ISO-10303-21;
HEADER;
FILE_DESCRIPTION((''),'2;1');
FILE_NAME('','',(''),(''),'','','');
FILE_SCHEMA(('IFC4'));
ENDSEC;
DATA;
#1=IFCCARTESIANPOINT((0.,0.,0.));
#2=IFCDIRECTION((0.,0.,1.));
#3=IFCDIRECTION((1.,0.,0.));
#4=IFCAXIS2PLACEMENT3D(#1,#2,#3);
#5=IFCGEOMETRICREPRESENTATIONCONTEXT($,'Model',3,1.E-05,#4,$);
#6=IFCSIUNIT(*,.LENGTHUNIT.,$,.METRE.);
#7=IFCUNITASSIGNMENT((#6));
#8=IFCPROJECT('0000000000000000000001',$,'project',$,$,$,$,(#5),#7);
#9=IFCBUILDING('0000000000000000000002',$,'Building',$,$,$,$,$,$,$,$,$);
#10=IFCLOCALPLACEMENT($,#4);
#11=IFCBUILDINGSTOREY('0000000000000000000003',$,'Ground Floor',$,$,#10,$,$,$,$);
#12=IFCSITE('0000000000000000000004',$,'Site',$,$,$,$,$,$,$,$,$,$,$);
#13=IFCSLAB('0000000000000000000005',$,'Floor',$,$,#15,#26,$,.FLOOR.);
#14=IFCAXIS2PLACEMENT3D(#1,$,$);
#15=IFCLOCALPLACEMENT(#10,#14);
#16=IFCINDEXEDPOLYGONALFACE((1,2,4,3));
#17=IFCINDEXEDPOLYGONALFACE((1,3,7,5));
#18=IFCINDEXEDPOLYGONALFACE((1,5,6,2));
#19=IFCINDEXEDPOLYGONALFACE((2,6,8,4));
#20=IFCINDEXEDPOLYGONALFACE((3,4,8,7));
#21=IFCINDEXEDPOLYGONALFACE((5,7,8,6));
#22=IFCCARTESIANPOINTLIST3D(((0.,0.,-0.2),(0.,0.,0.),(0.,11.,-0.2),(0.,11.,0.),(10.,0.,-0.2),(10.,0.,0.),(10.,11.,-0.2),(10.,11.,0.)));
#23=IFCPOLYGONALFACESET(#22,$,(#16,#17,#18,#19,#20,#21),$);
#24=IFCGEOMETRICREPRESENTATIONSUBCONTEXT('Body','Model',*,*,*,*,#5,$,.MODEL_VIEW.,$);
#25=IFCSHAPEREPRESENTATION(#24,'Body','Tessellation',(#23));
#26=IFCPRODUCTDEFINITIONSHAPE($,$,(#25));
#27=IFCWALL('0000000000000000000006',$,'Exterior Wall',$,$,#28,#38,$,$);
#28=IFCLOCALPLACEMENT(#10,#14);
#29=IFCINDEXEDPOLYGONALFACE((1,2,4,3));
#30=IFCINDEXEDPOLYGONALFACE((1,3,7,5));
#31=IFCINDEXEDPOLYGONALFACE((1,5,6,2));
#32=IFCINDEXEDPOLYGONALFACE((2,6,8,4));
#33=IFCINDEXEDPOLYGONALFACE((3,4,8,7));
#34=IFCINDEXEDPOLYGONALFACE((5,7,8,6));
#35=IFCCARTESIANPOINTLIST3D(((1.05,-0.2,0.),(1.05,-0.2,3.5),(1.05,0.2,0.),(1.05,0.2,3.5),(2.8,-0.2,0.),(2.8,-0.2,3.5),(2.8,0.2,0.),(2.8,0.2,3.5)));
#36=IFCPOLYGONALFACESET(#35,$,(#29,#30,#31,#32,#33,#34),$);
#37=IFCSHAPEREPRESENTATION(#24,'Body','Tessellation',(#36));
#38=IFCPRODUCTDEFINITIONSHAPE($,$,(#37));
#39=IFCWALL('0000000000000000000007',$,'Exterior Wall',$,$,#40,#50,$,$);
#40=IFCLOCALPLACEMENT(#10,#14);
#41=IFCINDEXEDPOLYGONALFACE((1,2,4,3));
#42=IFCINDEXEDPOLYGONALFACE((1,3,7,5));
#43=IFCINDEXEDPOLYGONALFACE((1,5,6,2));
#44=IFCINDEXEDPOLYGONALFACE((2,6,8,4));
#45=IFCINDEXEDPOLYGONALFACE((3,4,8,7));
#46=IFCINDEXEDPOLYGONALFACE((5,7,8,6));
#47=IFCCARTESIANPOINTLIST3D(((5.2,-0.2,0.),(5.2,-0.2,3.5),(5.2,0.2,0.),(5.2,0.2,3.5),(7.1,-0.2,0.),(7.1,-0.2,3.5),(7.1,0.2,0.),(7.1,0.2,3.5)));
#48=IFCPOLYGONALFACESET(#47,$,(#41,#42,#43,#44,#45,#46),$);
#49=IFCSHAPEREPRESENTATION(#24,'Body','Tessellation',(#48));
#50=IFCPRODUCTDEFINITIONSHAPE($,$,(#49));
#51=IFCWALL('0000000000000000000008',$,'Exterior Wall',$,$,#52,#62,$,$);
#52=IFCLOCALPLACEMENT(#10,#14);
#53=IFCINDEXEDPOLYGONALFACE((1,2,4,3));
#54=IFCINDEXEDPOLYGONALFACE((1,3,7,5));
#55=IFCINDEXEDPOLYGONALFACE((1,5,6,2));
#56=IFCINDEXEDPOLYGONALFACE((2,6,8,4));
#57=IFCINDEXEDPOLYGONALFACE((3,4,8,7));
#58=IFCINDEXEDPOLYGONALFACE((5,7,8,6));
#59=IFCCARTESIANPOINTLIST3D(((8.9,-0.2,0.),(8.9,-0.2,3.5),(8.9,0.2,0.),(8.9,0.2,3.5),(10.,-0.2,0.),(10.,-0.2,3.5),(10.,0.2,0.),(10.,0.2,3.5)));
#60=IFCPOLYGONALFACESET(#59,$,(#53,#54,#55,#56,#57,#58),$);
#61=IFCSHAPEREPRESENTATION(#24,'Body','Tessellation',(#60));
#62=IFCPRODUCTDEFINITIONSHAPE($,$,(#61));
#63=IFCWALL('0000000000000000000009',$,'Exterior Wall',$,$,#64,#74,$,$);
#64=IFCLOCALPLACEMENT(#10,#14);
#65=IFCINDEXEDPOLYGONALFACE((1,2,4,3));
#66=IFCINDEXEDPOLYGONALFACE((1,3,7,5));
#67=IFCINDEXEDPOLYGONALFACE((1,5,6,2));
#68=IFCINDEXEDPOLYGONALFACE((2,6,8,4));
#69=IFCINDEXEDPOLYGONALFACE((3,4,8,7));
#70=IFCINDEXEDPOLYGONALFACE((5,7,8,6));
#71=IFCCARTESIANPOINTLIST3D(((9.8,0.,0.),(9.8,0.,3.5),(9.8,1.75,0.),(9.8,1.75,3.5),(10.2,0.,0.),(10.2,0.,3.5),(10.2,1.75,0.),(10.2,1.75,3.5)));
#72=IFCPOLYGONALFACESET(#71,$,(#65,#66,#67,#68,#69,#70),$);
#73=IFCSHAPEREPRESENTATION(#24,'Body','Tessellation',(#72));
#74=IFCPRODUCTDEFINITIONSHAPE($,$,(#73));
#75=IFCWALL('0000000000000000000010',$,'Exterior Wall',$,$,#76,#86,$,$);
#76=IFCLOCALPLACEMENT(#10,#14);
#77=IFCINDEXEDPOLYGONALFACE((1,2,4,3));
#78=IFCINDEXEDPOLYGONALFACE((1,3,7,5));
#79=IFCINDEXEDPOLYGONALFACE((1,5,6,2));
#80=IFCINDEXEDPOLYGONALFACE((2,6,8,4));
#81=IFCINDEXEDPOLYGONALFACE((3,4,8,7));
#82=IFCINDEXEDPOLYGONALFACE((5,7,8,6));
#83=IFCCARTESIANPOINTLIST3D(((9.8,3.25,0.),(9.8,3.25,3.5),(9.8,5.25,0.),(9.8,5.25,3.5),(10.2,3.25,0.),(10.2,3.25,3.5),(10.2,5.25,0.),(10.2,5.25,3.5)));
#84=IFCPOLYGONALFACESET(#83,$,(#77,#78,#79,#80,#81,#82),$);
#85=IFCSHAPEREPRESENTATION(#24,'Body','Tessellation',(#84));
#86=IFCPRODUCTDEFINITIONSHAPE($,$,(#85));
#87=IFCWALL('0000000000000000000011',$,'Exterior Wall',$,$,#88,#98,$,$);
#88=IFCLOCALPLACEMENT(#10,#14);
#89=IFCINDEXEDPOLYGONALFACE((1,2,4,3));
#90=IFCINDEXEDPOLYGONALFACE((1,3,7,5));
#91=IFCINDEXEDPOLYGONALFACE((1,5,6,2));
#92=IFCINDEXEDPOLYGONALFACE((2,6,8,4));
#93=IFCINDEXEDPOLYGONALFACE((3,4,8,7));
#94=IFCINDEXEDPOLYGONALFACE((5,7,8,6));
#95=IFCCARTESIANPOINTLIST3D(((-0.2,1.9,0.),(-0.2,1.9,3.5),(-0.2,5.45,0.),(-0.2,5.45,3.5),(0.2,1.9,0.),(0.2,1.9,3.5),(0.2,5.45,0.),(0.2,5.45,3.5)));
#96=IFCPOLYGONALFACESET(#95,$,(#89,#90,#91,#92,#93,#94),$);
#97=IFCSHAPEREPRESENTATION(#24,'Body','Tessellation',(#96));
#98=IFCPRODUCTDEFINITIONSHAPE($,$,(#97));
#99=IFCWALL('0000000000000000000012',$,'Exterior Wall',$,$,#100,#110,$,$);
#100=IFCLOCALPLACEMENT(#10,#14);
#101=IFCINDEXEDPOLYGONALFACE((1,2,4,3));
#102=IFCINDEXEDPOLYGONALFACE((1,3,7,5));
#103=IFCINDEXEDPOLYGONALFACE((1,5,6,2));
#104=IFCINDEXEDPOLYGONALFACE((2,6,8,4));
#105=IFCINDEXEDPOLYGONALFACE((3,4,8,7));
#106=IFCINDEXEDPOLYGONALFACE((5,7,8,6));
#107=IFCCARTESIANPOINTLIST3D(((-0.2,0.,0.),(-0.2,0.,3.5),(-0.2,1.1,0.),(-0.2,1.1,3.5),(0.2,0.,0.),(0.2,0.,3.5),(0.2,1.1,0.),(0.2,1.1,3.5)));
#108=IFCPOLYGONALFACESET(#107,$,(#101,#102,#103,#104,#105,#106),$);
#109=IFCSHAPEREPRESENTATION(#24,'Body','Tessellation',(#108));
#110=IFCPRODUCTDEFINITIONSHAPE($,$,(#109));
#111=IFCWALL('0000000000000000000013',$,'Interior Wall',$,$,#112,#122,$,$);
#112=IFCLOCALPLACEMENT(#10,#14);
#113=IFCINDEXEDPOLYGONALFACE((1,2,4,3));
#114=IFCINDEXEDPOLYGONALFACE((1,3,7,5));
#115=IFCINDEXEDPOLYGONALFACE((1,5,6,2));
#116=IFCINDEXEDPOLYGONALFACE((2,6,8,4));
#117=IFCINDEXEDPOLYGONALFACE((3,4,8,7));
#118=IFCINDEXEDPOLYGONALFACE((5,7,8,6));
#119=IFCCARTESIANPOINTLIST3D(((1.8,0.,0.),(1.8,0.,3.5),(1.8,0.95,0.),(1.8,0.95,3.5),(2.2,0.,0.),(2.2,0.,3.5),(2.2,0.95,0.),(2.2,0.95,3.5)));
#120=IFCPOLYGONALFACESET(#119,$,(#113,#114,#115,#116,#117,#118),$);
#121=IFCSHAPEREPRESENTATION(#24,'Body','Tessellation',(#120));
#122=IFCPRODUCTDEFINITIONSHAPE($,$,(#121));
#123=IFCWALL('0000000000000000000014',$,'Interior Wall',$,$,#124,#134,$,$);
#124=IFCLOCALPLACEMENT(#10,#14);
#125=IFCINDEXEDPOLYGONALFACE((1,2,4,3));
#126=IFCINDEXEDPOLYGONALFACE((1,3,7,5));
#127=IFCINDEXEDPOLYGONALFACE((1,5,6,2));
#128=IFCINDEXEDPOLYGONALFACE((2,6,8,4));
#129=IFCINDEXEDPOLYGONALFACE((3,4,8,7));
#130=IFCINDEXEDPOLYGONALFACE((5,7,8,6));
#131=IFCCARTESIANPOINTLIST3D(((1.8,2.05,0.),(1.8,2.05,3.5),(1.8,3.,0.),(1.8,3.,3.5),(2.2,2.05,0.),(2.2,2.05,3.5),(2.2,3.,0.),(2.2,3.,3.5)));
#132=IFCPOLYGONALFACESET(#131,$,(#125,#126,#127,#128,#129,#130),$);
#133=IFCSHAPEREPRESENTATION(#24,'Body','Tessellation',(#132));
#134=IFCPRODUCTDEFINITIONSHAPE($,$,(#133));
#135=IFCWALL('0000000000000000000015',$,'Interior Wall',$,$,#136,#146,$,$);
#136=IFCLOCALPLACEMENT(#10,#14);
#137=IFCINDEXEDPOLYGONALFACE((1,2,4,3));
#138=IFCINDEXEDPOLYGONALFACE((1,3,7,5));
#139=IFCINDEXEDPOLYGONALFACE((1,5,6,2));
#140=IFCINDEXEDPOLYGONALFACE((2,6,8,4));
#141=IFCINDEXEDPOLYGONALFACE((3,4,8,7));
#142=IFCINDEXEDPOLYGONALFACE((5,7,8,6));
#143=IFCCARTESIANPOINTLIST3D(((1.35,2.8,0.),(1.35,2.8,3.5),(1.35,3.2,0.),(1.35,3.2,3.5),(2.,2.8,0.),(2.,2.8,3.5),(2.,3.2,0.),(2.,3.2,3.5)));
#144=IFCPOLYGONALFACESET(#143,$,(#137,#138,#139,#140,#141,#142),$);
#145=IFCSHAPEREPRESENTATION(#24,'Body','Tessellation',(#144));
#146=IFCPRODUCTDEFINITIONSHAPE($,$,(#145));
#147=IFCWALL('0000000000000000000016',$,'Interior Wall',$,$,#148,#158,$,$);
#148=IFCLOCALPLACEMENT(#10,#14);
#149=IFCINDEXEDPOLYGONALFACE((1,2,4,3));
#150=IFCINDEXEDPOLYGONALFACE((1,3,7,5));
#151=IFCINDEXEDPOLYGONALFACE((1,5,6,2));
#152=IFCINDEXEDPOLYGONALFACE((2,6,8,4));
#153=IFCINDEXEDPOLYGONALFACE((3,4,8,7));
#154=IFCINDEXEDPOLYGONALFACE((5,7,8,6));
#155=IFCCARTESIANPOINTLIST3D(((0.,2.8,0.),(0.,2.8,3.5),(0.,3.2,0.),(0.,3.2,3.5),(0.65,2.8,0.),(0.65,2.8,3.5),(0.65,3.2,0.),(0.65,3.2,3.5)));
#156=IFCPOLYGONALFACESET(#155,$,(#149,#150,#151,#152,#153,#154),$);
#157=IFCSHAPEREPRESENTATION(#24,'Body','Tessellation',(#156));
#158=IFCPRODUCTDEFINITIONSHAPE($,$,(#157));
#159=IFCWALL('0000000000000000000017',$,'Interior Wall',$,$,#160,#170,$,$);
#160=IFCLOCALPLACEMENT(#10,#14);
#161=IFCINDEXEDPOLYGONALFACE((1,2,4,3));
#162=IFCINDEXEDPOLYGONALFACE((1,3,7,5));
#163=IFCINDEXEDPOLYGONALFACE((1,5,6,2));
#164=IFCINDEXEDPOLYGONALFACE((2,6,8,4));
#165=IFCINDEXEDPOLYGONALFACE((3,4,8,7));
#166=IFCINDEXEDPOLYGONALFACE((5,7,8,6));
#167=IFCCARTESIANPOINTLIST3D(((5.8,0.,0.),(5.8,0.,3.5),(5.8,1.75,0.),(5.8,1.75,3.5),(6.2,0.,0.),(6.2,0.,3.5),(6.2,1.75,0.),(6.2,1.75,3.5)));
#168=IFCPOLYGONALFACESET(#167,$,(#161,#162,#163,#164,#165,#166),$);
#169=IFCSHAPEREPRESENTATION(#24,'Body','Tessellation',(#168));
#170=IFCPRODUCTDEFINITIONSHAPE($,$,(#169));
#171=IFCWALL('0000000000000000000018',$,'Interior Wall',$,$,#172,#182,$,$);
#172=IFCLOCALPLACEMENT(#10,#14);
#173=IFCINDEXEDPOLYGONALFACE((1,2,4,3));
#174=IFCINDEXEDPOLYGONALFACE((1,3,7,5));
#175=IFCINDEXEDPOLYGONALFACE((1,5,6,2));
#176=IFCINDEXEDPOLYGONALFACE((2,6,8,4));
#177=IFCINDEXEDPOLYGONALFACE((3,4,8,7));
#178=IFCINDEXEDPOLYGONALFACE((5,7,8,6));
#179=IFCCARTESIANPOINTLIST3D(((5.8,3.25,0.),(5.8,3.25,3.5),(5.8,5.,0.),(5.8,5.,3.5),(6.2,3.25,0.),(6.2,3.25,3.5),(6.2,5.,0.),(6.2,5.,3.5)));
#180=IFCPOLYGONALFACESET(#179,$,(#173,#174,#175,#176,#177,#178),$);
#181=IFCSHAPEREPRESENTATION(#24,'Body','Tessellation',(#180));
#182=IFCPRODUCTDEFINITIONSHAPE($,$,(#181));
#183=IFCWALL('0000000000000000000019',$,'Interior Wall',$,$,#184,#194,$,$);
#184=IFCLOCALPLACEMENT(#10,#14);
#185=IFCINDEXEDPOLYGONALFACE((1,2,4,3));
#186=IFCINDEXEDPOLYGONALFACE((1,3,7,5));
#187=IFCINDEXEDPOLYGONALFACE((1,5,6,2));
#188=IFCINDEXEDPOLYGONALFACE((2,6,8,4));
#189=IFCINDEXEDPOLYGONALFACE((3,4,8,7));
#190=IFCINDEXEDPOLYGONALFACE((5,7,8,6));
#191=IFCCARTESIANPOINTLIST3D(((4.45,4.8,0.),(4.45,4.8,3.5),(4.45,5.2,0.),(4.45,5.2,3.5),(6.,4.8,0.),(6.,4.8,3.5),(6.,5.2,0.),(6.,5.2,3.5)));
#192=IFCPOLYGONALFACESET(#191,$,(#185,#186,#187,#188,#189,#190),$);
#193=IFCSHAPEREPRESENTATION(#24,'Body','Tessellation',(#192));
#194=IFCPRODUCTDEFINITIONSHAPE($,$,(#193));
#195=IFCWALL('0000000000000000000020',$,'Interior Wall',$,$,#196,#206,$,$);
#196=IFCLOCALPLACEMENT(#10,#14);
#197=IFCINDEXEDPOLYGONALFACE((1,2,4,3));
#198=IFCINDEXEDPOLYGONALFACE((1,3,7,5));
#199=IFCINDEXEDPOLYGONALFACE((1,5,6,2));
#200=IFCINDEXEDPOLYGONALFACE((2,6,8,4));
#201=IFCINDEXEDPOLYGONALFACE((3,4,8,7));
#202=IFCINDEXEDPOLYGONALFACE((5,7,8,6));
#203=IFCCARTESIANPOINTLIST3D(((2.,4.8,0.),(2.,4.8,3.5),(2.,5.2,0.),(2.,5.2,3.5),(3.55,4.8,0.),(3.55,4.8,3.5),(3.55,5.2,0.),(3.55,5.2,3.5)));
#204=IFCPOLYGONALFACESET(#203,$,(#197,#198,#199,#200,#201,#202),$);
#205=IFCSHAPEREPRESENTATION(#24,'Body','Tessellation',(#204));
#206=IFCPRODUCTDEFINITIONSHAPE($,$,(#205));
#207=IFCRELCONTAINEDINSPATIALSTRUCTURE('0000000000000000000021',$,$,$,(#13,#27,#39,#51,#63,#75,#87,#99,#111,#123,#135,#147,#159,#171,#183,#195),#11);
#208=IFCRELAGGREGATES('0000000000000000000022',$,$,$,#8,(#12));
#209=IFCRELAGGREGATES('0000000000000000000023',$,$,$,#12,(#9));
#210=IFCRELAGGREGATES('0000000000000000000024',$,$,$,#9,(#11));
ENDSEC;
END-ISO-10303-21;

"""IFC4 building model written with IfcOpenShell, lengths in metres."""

from ifc_helpers import new_model, si_unit, frame, origin_with_axes, place, context, subcontext, project, spatial, indexed_curve, outline, extrude, element, save


model = new_model("IFC4")

# Units and contexts
model_context = context("Model", 3, precision=1e-05, world=origin_with_axes())
body_context = subcontext(model_context, "Body", "Model", "MODEL_VIEW")
ifc_project = project(units=[si_unit("LENGTHUNIT", "METRE")], contexts=[model_context])

# Site, building, storey
site = spatial("IfcSite", under=ifc_project, Name="Site")
building = spatial("IfcBuilding", under=site, Name="Building")
storey_placement = place(None, origin_with_axes())
storey = spatial("IfcBuildingStorey", under=building, at=storey_placement, Name="Ground Floor")

# Slab
slab_placement = place(storey_placement, frame((0.0, 0.0, -0.2), z_axis=(0.0, 0.0, 1.0), x_axis=(1.0, 0.0, 0.0)))
element("IfcSlab", 1, at=slab_placement, inside=storey, Name="Floor", PredefinedType="FLOOR", context=body_context, shape_type="SweptSolid", body=[
    extrude(outline(indexed_curve([(0.0, 0.0), (10.0, 0.0), (10.0, 11.0), (0.0, 11.0)])), None, (0.0, 0.0, 1.0), 0.2),
])

# Walls
wall_1_placement = place(storey_placement, frame((1.05, 0.0, 0.0), z_axis=(0.0, 0.0, 1.0), x_axis=(1.0, 0.0, 0.0)))
element("IfcWall", 2, at=wall_1_placement, inside=storey, Name="Exterior Wall", context=body_context, shape_type="SweptSolid", body=[
    extrude(outline(indexed_curve([(0.0, 0.0), (0.0, 0.4), (1.75, 0.4), (1.75, 0.0), (0.0, 0.0)], self_intersect=False)), frame((0.0, -0.2, 0.0), z_axis=(0.0, 0.0, 1.0), x_axis=(1.0, 0.0, 0.0)), (0.0, 0.0, 1.0), 3.5),
])
wall_2_placement = place(storey_placement, frame((5.2, 0.0, 0.0), z_axis=(0.0, 0.0, 1.0), x_axis=(1.0, 0.0, 0.0)))
element("IfcWall", 3, at=wall_2_placement, inside=storey, Name="Exterior Wall", context=body_context, shape_type="SweptSolid", body=[
    extrude(outline(indexed_curve([(0.0, 0.0), (0.0, 0.4), (1.9, 0.4), (1.9, 0.0), (0.0, 0.0)], self_intersect=False)), frame((0.0, -0.2, 0.0), z_axis=(0.0, 0.0, 1.0), x_axis=(1.0, 0.0, 0.0)), (0.0, 0.0, 1.0), 3.5),
])
wall_3_placement = place(storey_placement, frame((8.9, 0.0, 0.0), z_axis=(0.0, 0.0, 1.0), x_axis=(1.0, 0.0, 0.0)))
element("IfcWall", 4, at=wall_3_placement, inside=storey, Name="Exterior Wall", context=body_context, shape_type="SweptSolid", body=[
    extrude(outline(indexed_curve([(0.0, 0.0), (0.0, 0.4), (1.1, 0.4), (1.1, 0.0), (0.0, 0.0)], self_intersect=False)), frame((0.0, -0.2, 0.0), z_axis=(0.0, 0.0, 1.0), x_axis=(1.0, 0.0, 0.0)), (0.0, 0.0, 1.0), 3.5),
])
wall_4_placement = place(storey_placement, frame((10.0, 0.0, 0.0), z_axis=(0.0, 0.0, 1.0), x_axis=(0.0, 1.0, 0.0)))
element("IfcWall", 5, at=wall_4_placement, inside=storey, Name="Exterior Wall", context=body_context, shape_type="SweptSolid", body=[
    extrude(outline(indexed_curve([(0.0, 0.0), (0.0, 0.4), (1.75, 0.4), (1.75, 0.0), (0.0, 0.0)], self_intersect=False)), frame((0.0, -0.2, 0.0), z_axis=(0.0, 0.0, 1.0), x_axis=(1.0, 0.0, 0.0)), (0.0, 0.0, 1.0), 3.5),
])
wall_5_placement = place(storey_placement, frame((10.0, 3.25, 0.0), z_axis=(0.0, 0.0, 1.0), x_axis=(0.0, 1.0, 0.0)))
element("IfcWall", 6, at=wall_5_placement, inside=storey, Name="Exterior Wall", context=body_context, shape_type="SweptSolid", body=[
    extrude(outline(indexed_curve([(0.0, 0.0), (0.0, 0.4), (2.0, 0.4), (2.0, 0.0), (0.0, 0.0)], self_intersect=False)), frame((0.0, -0.2, 0.0), z_axis=(0.0, 0.0, 1.0), x_axis=(1.0, 0.0, 0.0)), (0.0, 0.0, 1.0), 3.5),
])
wall_6_placement = place(storey_placement, frame((0.0, 5.45, 0.0), z_axis=(0.0, 0.0, 1.0), x_axis=(0.0, -1.0, 0.0)))
element("IfcWall", 7, at=wall_6_placement, inside=storey, Name="Exterior Wall", context=body_context, shape_type="SweptSolid", body=[
    extrude(outline(indexed_curve([(0.0, 0.0), (0.0, 0.4), (3.55, 0.4), (3.55, 0.0), (0.0, 0.0)], self_intersect=False)), frame((0.0, -0.2, 0.0), z_axis=(0.0, 0.0, 1.0), x_axis=(1.0, 0.0, 0.0)), (0.0, 0.0, 1.0), 3.5),
])
wall_7_placement = place(storey_placement, frame((0.0, 1.1, 0.0), z_axis=(0.0, 0.0, 1.0), x_axis=(0.0, -1.0, 0.0)))
element("IfcWall", 8, at=wall_7_placement, inside=storey, Name="Exterior Wall", context=body_context, shape_type="SweptSolid", body=[
    extrude(outline(indexed_curve([(0.0, 0.0), (0.0, 0.4), (1.1, 0.4), (1.1, 0.0), (0.0, 0.0)], self_intersect=False)), frame((0.0, -0.2, 0.0), z_axis=(0.0, 0.0, 1.0), x_axis=(1.0, 0.0, 0.0)), (0.0, 0.0, 1.0), 3.5),
])
wall_8_placement = place(storey_placement, frame((2.0, 0.0, 0.0), z_axis=(0.0, 0.0, 1.0), x_axis=(0.0, 1.0, 0.0)))
element("IfcWall", 9, at=wall_8_placement, inside=storey, Name="Interior Wall", context=body_context, shape_type="SweptSolid", body=[
    extrude(outline(indexed_curve([(0.0, 0.0), (0.0, 0.4), (0.95, 0.4), (0.95, 0.0), (0.0, 0.0)], self_intersect=False)), frame((0.0, -0.2, 0.0), z_axis=(0.0, 0.0, 1.0), x_axis=(1.0, 0.0, 0.0)), (0.0, 0.0, 1.0), 3.5),
])
wall_9_placement = place(storey_placement, frame((2.0, 2.05, 0.0), z_axis=(0.0, 0.0, 1.0), x_axis=(0.0, 1.0, 0.0)))
element("IfcWall", 10, at=wall_9_placement, inside=storey, Name="Interior Wall", context=body_context, shape_type="SweptSolid", body=[
    extrude(outline(indexed_curve([(0.0, 0.0), (0.0, 0.4), (0.95, 0.4), (0.95, 0.0), (0.0, 0.0)], self_intersect=False)), frame((0.0, -0.2, 0.0), z_axis=(0.0, 0.0, 1.0), x_axis=(1.0, 0.0, 0.0)), (0.0, 0.0, 1.0), 3.5),
])
for number, where, z_axis, x_axis, name in (
    (11, (2.0, 3.0, 0.0), (0.0, 0.0, 1.0), (-1.0, 0.0, 0.0), "Interior Wall"),
    (12, (0.65, 3.0, 0.0), (0.0, 0.0, 1.0), (-1.0, 0.0, 0.0), "Interior Wall"),
):
    element("IfcWall", number, at=place(storey_placement, frame(where, z_axis=z_axis, x_axis=x_axis)), inside=storey, Name=name, context=body_context, shape_type="SweptSolid", body=[
        extrude(outline(indexed_curve([(0.0, 0.0), (0.0, 0.4), (0.65, 0.4), (0.65, 0.0), (0.0, 0.0)], self_intersect=False)), frame((0.0, -0.2, 0.0), z_axis=(0.0, 0.0, 1.0), x_axis=(1.0, 0.0, 0.0)), (0.0, 0.0, 1.0), 3.5),
    ])
for number, where, z_axis, x_axis, name in (
    (13, (6.0, 0.0, 0.0), (0.0, 0.0, 1.0), (0.0, 1.0, 0.0), "Interior Wall"),
    (14, (6.0, 3.25, 0.0), (0.0, 0.0, 1.0), (0.0, 1.0, 0.0), "Interior Wall"),
):
    element("IfcWall", number, at=place(storey_placement, frame(where, z_axis=z_axis, x_axis=x_axis)), inside=storey, Name=name, context=body_context, shape_type="SweptSolid", body=[
        extrude(outline(indexed_curve([(0.0, 0.0), (0.0, 0.4), (1.75, 0.4), (1.75, 0.0), (0.0, 0.0)], self_intersect=False)), frame((0.0, -0.2, 0.0), z_axis=(0.0, 0.0, 1.0), x_axis=(1.0, 0.0, 0.0)), (0.0, 0.0, 1.0), 3.5),
    ])
for number, where, z_axis, x_axis, name in (
    (15, (6.0, 5.0, 0.0), (0.0, 0.0, 1.0), (-1.0, 0.0, 0.0), "Interior Wall"),
    (16, (3.55, 5.0, 0.0), (0.0, 0.0, 1.0), (-1.0, 0.0, 0.0), "Interior Wall"),
):
    element("IfcWall", number, at=place(storey_placement, frame(where, z_axis=z_axis, x_axis=x_axis)), inside=storey, Name=name, context=body_context, shape_type="SweptSolid", body=[
        extrude(outline(indexed_curve([(0.0, 0.0), (0.0, 0.4), (1.55, 0.4), (1.55, 0.0), (0.0, 0.0)], self_intersect=False)), frame((0.0, -0.2, 0.0), z_axis=(0.0, 0.0, 1.0), x_axis=(1.0, 0.0, 0.0)), (0.0, 0.0, 1.0), 3.5),
    ])

save(model, "model.ifc")
